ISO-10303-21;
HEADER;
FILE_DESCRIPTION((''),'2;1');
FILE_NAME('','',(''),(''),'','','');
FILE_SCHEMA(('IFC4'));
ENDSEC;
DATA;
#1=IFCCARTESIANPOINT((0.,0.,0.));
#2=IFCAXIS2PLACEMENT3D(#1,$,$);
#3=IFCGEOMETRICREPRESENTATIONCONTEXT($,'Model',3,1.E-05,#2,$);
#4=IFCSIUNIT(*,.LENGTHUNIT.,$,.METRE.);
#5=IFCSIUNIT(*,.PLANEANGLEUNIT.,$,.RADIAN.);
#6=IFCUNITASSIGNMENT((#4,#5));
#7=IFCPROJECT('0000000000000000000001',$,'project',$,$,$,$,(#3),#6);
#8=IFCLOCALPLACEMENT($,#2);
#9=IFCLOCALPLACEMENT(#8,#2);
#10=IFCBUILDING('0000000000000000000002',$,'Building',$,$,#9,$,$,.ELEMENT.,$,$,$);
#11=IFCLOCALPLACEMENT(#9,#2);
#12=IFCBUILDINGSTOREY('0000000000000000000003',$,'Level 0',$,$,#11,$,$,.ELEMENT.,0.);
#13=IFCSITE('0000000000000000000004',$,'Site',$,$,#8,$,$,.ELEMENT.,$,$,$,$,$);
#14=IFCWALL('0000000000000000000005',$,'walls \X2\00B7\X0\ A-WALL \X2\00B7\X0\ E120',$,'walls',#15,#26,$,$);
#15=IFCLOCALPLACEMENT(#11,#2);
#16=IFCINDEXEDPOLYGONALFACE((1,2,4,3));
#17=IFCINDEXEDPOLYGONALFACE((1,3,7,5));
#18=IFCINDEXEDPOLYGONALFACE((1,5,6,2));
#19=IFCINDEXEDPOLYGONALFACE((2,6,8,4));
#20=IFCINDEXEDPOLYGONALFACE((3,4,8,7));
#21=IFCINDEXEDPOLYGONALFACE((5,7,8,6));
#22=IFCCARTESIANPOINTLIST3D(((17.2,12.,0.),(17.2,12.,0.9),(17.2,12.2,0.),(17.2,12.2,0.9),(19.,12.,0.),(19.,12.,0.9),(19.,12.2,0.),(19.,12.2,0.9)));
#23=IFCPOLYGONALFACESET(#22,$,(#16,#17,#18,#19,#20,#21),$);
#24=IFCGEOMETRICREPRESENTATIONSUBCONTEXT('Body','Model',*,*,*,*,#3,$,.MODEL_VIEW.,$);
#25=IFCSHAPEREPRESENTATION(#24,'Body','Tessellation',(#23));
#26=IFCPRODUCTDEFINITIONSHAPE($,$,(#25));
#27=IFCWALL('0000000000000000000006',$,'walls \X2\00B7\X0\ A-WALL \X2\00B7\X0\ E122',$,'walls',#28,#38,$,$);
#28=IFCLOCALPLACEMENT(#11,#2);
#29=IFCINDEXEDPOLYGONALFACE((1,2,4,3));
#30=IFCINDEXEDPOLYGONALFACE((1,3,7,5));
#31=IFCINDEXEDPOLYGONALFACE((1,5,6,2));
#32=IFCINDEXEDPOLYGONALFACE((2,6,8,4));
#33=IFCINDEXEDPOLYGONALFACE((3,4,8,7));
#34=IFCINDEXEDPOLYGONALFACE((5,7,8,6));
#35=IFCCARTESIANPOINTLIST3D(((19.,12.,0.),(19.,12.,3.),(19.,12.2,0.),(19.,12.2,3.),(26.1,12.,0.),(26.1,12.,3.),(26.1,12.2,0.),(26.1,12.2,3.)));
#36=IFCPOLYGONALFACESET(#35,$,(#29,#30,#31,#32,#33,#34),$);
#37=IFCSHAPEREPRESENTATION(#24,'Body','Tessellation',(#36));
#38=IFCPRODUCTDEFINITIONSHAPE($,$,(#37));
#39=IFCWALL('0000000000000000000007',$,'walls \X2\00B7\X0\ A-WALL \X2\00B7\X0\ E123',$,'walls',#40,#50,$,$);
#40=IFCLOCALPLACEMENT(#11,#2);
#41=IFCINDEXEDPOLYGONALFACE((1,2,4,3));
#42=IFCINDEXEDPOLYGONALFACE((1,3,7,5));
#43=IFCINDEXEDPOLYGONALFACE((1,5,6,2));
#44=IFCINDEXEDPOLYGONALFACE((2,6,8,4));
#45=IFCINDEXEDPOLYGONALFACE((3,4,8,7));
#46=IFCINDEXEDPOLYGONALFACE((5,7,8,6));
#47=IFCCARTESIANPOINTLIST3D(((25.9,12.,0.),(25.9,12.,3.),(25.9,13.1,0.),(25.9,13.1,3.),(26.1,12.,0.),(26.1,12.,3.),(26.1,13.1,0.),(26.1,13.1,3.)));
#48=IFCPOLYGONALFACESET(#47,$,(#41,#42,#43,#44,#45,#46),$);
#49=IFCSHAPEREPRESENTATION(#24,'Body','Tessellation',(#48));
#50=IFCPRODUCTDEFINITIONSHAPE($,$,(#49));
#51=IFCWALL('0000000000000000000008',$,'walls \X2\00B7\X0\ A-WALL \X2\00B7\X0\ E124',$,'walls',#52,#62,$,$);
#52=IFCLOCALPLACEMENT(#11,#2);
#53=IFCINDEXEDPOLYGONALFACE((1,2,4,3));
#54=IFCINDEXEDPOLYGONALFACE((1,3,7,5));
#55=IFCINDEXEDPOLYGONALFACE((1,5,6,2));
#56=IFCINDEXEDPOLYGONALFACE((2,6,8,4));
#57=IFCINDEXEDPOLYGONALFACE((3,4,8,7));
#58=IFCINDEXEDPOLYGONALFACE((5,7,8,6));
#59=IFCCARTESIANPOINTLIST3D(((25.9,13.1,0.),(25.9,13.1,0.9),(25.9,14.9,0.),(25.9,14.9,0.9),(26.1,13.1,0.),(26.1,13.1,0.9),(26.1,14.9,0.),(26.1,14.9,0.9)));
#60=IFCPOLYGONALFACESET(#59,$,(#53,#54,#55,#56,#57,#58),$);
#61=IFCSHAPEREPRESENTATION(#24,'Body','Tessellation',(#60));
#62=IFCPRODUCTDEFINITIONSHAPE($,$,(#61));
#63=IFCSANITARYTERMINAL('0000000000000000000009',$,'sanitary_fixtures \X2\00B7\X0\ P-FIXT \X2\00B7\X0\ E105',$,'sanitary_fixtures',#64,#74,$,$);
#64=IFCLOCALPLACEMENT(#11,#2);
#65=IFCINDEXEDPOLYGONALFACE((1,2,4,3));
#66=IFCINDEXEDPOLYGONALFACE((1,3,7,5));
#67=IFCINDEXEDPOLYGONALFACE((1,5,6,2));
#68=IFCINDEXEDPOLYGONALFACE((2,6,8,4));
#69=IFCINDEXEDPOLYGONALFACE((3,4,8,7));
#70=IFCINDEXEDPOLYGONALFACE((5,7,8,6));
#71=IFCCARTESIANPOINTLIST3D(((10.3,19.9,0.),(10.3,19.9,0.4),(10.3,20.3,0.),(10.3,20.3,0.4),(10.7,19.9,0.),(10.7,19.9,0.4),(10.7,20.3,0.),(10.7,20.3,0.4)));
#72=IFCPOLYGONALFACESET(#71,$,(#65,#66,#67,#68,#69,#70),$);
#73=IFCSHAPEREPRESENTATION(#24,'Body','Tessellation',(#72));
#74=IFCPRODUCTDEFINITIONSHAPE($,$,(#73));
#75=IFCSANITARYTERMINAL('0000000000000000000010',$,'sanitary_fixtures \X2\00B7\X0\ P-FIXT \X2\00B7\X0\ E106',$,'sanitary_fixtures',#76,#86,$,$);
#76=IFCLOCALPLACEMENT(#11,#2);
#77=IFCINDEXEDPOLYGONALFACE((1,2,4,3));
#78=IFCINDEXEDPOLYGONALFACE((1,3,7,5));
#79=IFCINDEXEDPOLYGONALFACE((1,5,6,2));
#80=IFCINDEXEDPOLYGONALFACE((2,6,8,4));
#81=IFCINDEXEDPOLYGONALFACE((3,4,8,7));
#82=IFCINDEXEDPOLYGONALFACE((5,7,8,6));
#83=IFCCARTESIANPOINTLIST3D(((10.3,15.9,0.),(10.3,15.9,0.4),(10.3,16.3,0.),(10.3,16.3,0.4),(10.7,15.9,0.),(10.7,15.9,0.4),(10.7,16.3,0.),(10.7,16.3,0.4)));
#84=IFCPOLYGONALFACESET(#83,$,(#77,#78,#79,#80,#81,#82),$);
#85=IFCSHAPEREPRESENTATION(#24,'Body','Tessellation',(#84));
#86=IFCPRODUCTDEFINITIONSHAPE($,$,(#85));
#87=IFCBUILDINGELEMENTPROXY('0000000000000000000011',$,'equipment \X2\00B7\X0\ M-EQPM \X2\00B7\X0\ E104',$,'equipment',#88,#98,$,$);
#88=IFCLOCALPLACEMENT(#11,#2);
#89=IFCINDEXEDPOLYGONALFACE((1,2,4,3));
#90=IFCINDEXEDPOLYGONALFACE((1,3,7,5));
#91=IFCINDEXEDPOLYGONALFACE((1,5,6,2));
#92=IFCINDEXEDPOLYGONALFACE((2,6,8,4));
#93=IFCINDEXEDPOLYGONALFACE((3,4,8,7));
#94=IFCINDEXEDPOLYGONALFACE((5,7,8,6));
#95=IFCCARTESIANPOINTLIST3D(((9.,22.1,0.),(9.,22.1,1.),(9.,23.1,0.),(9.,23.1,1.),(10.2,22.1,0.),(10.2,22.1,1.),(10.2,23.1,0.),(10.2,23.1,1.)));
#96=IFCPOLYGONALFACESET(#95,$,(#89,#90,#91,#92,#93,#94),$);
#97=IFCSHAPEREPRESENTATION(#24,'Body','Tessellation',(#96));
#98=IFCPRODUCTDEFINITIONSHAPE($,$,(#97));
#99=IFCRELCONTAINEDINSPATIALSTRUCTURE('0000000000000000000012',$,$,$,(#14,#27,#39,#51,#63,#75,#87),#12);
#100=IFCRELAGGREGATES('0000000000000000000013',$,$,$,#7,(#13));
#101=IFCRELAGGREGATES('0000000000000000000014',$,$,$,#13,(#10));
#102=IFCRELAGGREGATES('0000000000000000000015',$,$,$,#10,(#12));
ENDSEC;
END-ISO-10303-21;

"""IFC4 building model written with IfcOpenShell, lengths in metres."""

from ifc_helpers import new_model, si_unit, frame, origin, place, context, subcontext, project, spatial, polyline, outline, extrude, element, save


model = new_model("IFC4")

# Units and contexts
model_context = context("Model", 3, precision=1e-05, world=origin())
body_context = subcontext(model_context, "Body", "Model", "MODEL_VIEW")
ifc_project = project(units=[si_unit("LENGTHUNIT", "METRE"), si_unit("PLANEANGLEUNIT", "RADIAN")], contexts=[model_context])

# Site, building, storey
site_placement = place(None, origin())
site = spatial("IfcSite", under=ifc_project, at=site_placement, Name="Site", CompositionType="ELEMENT")
building_placement = place(site_placement, origin())
building = spatial("IfcBuilding", under=site, at=building_placement, Name="Building", CompositionType="ELEMENT")
storey_placement = place(building_placement, origin())
storey = spatial("IfcBuildingStorey", under=building, at=storey_placement, Name="Level 0", CompositionType="ELEMENT", Elevation=0.0)

# Wall, opening
wall_1_placement = place(storey_placement, origin())
wall_1 = element("IfcWall", 1, at=wall_1_placement, inside=storey, Name="walls · A-WALL · E120", ObjectType="walls", context=body_context, shape_type="SweptSolid", body=[
    extrude(outline(polyline([(17.2, 12.0), (19.0, 12.0), (19.0, 12.2), (17.2, 12.2), (17.2, 12.0)])), origin(), (0.0, 0.0, 1.0), 0.9),
])
opening_1_placement = place(storey_placement, frame((0.0, 0.0, 0.9)))
element("IfcOpeningElement", 2, at=opening_1_placement, cuts=wall_1, ObjectType="Opening", context=body_context, shape_type="SweptSolid", body=[
    extrude(outline(polyline([(17.2, 12.0), (19.0, 12.0), (19.0, 12.2), (17.2, 12.2), (17.2, 12.0)])), origin(), (0.0, 0.0, 1.0), 1.4),
])

# Walls
wall_2_placement = place(storey_placement, origin())
element("IfcWall", 3, at=wall_2_placement, inside=storey, Name="walls · A-WALL · E122", ObjectType="walls", context=body_context, shape_type="SweptSolid", body=[
    extrude(outline(polyline([(19.0, 12.0), (26.1, 12.0), (26.1, 12.2), (19.0, 12.2), (19.0, 12.0)])), origin(), (0.0, 0.0, 1.0), 3.0),
])
wall_3_placement = place(storey_placement, origin())
element("IfcWall", 4, at=wall_3_placement, inside=storey, Name="walls · A-WALL · E123", ObjectType="walls", context=body_context, shape_type="SweptSolid", body=[
    extrude(outline(polyline([(26.1, 12.0), (26.1, 13.1), (25.9, 13.1), (25.9, 12.0), (26.1, 12.0)])), origin(), (0.0, 0.0, 1.0), 3.0),
])

# Wall, opening
wall_4_placement = place(storey_placement, origin())
wall_4 = element("IfcWall", 5, at=wall_4_placement, inside=storey, Name="walls · A-WALL · E124", ObjectType="walls", context=body_context, shape_type="SweptSolid", body=[
    extrude(outline(polyline([(26.1, 13.1), (26.1, 14.9), (25.9, 14.9), (25.9, 13.1), (26.1, 13.1)])), origin(), (0.0, 0.0, 1.0), 0.9),
])
opening_2_placement = place(storey_placement, frame((0.0, 0.0, 0.9)))
element("IfcOpeningElement", 6, at=opening_2_placement, cuts=wall_4, ObjectType="Opening", context=body_context, shape_type="SweptSolid", body=[
    extrude(outline(polyline([(26.1, 13.1), (26.1, 14.9), (25.9, 14.9), (25.9, 13.1), (26.1, 13.1)])), origin(), (0.0, 0.0, 1.0), 1.4),
])

# Sanitary terminals
sanitary_terminal_1_placement = place(storey_placement, origin())
element("IfcSanitaryTerminal", 7, at=sanitary_terminal_1_placement, inside=storey, Name="sanitary_fixtures · P-FIXT · E105", ObjectType="sanitary_fixtures", context=body_context, shape_type="SweptSolid", body=[
    extrude(outline(polyline([(10.3, 19.9), (10.7, 19.9), (10.7, 20.3), (10.3, 20.3), (10.3, 19.9)])), origin(), (0.0, 0.0, 1.0), 0.4),
])
sanitary_terminal_2_placement = place(storey_placement, origin())
element("IfcSanitaryTerminal", 8, at=sanitary_terminal_2_placement, inside=storey, Name="sanitary_fixtures · P-FIXT · E106", ObjectType="sanitary_fixtures", context=body_context, shape_type="SweptSolid", body=[
    extrude(outline(polyline([(10.3, 15.9), (10.7, 15.9), (10.7, 16.3), (10.3, 16.3), (10.3, 15.9)])), origin(), (0.0, 0.0, 1.0), 0.4),
])

# Building element proxy
proxy_placement = place(storey_placement, origin())
element("IfcBuildingElementProxy", 9, at=proxy_placement, inside=storey, Name="equipment · M-EQPM · E104", ObjectType="equipment", context=body_context, shape_type="SweptSolid", body=[
    extrude(outline(polyline([(9.0, 22.1), (10.2, 22.1), (10.2, 23.1), (9.0, 23.1), (9.0, 22.1)])), origin(), (0.0, 0.0, 1.0), 1.0),
])

save(model, "model.ifc")
